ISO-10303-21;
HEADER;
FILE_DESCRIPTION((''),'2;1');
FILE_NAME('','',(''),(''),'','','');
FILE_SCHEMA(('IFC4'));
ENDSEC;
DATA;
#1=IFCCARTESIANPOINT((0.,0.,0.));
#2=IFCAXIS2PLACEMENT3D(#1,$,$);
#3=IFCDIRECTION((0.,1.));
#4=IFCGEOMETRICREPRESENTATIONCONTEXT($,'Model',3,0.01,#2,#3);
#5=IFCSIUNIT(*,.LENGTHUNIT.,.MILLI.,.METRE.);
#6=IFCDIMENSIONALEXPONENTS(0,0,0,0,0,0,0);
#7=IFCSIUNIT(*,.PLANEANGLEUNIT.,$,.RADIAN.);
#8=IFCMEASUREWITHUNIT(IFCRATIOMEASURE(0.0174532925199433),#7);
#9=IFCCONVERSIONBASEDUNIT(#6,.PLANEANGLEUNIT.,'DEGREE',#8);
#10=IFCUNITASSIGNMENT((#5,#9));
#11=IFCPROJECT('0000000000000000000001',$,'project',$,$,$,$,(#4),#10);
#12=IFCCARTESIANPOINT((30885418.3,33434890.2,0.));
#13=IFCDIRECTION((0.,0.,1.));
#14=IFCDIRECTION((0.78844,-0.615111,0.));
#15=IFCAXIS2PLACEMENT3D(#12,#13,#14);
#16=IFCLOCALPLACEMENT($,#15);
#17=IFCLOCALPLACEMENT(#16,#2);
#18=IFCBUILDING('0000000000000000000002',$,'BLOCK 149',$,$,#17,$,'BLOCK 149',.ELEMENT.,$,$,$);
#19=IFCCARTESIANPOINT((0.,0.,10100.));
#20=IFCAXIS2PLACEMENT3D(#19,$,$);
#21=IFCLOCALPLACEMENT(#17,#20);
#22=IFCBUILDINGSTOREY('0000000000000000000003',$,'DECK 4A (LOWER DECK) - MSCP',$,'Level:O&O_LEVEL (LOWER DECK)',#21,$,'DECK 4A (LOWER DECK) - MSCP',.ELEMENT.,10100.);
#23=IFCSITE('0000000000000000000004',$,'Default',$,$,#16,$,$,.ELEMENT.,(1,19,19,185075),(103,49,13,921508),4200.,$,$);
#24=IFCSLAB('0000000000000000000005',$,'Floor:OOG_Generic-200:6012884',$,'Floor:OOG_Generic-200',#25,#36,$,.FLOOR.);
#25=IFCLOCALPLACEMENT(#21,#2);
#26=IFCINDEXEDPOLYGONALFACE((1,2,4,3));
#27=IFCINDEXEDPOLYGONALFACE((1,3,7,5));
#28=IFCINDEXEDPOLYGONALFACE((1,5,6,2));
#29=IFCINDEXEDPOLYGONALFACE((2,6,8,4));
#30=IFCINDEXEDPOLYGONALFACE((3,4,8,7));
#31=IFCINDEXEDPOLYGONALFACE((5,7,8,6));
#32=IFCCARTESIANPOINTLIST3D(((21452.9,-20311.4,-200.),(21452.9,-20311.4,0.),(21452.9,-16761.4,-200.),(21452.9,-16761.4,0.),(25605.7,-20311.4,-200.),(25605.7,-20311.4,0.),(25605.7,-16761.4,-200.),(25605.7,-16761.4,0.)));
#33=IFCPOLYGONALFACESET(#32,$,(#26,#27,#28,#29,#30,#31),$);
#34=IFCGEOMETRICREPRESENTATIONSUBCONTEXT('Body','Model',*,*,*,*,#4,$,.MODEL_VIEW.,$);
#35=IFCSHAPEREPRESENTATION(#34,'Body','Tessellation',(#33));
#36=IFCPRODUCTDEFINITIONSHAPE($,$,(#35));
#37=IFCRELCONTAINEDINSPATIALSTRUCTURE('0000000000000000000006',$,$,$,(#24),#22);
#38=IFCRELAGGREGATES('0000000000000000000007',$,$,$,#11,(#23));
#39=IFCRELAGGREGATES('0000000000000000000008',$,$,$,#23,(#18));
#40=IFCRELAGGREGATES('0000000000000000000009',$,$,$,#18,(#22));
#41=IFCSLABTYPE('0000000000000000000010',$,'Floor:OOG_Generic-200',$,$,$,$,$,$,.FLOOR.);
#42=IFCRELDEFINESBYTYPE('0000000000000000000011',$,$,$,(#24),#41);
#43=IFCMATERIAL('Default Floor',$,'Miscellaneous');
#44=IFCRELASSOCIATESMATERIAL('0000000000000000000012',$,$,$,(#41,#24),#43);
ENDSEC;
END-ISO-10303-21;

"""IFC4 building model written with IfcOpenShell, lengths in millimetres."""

from ifc_helpers import new_model, entity, si_unit, converted_unit, direction, frame, origin, place, context, subcontext, project, spatial, indexed_curve, outline, extrude, material, type_object, element, save


model = new_model("IFC4")

# Units and contexts
model_context = context("Model", 3, precision=0.01, world=origin(), true_north=direction((0.0, 1.0)))
body_context = subcontext(model_context, "Body", "Model", "MODEL_VIEW")
ifc_project = project(units=[si_unit("LENGTHUNIT", "METRE", prefix="MILLI"), converted_unit("PLANEANGLEUNIT", "DEGREE", entity("IfcRatioMeasure", 0.0174532925199433), si_unit("PLANEANGLEUNIT", "RADIAN"), dimensions=[0, 0, 0, 0, 0, 0, 0])], contexts=[model_context])

# Site, building, storey
site_placement = place(None, frame((30885418.3, 33434890.2, 0.0), z_axis=(0.0, 0.0, 1.0), x_axis=(0.78844, -0.615111, 0.0)))
site = spatial("IfcSite", under=ifc_project, at=site_placement, Name="Default", CompositionType="ELEMENT", RefLatitude=(1, 19, 19, 185075), RefLongitude=(103, 49, 13, 921508), RefElevation=4200.0)
building_placement = place(site_placement, origin())
building = spatial("IfcBuilding", under=site, at=building_placement, Name="BLOCK 149", LongName="BLOCK 149", CompositionType="ELEMENT")
storey_placement = place(building_placement, frame((0.0, 0.0, 10100.0)))
storey = spatial("IfcBuildingStorey", under=building, at=storey_placement, Name="DECK 4A (LOWER DECK) - MSCP", ObjectType="Level:O&O_LEVEL (LOWER DECK)", LongName="DECK 4A (LOWER DECK) - MSCP", CompositionType="ELEMENT", Elevation=10100.0)

# Slab
ifc_material = material(Name="Default Floor", Category="Miscellaneous")
slab_type = type_object("IfcSlabType", Name="Floor:OOG_Generic-200", PredefinedType="FLOOR", material=ifc_material)
slab_placement = place(storey_placement, origin())
element("IfcSlab", 1, at=slab_placement, inside=storey, type_object=slab_type, material=ifc_material, Name="Floor:OOG_Generic-200:6012884", ObjectType="Floor:OOG_Generic-200", PredefinedType="FLOOR", context=body_context, shape_type="SweptSolid", body=[
    extrude(outline(indexed_curve([(-1775.0, -2076.4), (1775.0, -2076.4), (1775.0, 2076.4), (-1775.0, 2076.4), (-1775.0, -2076.4)], self_intersect=False)), frame((23529.3, -18536.4, 0.0), z_axis=(0.0, 0.0, -1.0), x_axis=(0.0, 1.0, 0.0)), (0.0, 0.0, 1.0), 200.0),
])

save(model, "model.ifc")
